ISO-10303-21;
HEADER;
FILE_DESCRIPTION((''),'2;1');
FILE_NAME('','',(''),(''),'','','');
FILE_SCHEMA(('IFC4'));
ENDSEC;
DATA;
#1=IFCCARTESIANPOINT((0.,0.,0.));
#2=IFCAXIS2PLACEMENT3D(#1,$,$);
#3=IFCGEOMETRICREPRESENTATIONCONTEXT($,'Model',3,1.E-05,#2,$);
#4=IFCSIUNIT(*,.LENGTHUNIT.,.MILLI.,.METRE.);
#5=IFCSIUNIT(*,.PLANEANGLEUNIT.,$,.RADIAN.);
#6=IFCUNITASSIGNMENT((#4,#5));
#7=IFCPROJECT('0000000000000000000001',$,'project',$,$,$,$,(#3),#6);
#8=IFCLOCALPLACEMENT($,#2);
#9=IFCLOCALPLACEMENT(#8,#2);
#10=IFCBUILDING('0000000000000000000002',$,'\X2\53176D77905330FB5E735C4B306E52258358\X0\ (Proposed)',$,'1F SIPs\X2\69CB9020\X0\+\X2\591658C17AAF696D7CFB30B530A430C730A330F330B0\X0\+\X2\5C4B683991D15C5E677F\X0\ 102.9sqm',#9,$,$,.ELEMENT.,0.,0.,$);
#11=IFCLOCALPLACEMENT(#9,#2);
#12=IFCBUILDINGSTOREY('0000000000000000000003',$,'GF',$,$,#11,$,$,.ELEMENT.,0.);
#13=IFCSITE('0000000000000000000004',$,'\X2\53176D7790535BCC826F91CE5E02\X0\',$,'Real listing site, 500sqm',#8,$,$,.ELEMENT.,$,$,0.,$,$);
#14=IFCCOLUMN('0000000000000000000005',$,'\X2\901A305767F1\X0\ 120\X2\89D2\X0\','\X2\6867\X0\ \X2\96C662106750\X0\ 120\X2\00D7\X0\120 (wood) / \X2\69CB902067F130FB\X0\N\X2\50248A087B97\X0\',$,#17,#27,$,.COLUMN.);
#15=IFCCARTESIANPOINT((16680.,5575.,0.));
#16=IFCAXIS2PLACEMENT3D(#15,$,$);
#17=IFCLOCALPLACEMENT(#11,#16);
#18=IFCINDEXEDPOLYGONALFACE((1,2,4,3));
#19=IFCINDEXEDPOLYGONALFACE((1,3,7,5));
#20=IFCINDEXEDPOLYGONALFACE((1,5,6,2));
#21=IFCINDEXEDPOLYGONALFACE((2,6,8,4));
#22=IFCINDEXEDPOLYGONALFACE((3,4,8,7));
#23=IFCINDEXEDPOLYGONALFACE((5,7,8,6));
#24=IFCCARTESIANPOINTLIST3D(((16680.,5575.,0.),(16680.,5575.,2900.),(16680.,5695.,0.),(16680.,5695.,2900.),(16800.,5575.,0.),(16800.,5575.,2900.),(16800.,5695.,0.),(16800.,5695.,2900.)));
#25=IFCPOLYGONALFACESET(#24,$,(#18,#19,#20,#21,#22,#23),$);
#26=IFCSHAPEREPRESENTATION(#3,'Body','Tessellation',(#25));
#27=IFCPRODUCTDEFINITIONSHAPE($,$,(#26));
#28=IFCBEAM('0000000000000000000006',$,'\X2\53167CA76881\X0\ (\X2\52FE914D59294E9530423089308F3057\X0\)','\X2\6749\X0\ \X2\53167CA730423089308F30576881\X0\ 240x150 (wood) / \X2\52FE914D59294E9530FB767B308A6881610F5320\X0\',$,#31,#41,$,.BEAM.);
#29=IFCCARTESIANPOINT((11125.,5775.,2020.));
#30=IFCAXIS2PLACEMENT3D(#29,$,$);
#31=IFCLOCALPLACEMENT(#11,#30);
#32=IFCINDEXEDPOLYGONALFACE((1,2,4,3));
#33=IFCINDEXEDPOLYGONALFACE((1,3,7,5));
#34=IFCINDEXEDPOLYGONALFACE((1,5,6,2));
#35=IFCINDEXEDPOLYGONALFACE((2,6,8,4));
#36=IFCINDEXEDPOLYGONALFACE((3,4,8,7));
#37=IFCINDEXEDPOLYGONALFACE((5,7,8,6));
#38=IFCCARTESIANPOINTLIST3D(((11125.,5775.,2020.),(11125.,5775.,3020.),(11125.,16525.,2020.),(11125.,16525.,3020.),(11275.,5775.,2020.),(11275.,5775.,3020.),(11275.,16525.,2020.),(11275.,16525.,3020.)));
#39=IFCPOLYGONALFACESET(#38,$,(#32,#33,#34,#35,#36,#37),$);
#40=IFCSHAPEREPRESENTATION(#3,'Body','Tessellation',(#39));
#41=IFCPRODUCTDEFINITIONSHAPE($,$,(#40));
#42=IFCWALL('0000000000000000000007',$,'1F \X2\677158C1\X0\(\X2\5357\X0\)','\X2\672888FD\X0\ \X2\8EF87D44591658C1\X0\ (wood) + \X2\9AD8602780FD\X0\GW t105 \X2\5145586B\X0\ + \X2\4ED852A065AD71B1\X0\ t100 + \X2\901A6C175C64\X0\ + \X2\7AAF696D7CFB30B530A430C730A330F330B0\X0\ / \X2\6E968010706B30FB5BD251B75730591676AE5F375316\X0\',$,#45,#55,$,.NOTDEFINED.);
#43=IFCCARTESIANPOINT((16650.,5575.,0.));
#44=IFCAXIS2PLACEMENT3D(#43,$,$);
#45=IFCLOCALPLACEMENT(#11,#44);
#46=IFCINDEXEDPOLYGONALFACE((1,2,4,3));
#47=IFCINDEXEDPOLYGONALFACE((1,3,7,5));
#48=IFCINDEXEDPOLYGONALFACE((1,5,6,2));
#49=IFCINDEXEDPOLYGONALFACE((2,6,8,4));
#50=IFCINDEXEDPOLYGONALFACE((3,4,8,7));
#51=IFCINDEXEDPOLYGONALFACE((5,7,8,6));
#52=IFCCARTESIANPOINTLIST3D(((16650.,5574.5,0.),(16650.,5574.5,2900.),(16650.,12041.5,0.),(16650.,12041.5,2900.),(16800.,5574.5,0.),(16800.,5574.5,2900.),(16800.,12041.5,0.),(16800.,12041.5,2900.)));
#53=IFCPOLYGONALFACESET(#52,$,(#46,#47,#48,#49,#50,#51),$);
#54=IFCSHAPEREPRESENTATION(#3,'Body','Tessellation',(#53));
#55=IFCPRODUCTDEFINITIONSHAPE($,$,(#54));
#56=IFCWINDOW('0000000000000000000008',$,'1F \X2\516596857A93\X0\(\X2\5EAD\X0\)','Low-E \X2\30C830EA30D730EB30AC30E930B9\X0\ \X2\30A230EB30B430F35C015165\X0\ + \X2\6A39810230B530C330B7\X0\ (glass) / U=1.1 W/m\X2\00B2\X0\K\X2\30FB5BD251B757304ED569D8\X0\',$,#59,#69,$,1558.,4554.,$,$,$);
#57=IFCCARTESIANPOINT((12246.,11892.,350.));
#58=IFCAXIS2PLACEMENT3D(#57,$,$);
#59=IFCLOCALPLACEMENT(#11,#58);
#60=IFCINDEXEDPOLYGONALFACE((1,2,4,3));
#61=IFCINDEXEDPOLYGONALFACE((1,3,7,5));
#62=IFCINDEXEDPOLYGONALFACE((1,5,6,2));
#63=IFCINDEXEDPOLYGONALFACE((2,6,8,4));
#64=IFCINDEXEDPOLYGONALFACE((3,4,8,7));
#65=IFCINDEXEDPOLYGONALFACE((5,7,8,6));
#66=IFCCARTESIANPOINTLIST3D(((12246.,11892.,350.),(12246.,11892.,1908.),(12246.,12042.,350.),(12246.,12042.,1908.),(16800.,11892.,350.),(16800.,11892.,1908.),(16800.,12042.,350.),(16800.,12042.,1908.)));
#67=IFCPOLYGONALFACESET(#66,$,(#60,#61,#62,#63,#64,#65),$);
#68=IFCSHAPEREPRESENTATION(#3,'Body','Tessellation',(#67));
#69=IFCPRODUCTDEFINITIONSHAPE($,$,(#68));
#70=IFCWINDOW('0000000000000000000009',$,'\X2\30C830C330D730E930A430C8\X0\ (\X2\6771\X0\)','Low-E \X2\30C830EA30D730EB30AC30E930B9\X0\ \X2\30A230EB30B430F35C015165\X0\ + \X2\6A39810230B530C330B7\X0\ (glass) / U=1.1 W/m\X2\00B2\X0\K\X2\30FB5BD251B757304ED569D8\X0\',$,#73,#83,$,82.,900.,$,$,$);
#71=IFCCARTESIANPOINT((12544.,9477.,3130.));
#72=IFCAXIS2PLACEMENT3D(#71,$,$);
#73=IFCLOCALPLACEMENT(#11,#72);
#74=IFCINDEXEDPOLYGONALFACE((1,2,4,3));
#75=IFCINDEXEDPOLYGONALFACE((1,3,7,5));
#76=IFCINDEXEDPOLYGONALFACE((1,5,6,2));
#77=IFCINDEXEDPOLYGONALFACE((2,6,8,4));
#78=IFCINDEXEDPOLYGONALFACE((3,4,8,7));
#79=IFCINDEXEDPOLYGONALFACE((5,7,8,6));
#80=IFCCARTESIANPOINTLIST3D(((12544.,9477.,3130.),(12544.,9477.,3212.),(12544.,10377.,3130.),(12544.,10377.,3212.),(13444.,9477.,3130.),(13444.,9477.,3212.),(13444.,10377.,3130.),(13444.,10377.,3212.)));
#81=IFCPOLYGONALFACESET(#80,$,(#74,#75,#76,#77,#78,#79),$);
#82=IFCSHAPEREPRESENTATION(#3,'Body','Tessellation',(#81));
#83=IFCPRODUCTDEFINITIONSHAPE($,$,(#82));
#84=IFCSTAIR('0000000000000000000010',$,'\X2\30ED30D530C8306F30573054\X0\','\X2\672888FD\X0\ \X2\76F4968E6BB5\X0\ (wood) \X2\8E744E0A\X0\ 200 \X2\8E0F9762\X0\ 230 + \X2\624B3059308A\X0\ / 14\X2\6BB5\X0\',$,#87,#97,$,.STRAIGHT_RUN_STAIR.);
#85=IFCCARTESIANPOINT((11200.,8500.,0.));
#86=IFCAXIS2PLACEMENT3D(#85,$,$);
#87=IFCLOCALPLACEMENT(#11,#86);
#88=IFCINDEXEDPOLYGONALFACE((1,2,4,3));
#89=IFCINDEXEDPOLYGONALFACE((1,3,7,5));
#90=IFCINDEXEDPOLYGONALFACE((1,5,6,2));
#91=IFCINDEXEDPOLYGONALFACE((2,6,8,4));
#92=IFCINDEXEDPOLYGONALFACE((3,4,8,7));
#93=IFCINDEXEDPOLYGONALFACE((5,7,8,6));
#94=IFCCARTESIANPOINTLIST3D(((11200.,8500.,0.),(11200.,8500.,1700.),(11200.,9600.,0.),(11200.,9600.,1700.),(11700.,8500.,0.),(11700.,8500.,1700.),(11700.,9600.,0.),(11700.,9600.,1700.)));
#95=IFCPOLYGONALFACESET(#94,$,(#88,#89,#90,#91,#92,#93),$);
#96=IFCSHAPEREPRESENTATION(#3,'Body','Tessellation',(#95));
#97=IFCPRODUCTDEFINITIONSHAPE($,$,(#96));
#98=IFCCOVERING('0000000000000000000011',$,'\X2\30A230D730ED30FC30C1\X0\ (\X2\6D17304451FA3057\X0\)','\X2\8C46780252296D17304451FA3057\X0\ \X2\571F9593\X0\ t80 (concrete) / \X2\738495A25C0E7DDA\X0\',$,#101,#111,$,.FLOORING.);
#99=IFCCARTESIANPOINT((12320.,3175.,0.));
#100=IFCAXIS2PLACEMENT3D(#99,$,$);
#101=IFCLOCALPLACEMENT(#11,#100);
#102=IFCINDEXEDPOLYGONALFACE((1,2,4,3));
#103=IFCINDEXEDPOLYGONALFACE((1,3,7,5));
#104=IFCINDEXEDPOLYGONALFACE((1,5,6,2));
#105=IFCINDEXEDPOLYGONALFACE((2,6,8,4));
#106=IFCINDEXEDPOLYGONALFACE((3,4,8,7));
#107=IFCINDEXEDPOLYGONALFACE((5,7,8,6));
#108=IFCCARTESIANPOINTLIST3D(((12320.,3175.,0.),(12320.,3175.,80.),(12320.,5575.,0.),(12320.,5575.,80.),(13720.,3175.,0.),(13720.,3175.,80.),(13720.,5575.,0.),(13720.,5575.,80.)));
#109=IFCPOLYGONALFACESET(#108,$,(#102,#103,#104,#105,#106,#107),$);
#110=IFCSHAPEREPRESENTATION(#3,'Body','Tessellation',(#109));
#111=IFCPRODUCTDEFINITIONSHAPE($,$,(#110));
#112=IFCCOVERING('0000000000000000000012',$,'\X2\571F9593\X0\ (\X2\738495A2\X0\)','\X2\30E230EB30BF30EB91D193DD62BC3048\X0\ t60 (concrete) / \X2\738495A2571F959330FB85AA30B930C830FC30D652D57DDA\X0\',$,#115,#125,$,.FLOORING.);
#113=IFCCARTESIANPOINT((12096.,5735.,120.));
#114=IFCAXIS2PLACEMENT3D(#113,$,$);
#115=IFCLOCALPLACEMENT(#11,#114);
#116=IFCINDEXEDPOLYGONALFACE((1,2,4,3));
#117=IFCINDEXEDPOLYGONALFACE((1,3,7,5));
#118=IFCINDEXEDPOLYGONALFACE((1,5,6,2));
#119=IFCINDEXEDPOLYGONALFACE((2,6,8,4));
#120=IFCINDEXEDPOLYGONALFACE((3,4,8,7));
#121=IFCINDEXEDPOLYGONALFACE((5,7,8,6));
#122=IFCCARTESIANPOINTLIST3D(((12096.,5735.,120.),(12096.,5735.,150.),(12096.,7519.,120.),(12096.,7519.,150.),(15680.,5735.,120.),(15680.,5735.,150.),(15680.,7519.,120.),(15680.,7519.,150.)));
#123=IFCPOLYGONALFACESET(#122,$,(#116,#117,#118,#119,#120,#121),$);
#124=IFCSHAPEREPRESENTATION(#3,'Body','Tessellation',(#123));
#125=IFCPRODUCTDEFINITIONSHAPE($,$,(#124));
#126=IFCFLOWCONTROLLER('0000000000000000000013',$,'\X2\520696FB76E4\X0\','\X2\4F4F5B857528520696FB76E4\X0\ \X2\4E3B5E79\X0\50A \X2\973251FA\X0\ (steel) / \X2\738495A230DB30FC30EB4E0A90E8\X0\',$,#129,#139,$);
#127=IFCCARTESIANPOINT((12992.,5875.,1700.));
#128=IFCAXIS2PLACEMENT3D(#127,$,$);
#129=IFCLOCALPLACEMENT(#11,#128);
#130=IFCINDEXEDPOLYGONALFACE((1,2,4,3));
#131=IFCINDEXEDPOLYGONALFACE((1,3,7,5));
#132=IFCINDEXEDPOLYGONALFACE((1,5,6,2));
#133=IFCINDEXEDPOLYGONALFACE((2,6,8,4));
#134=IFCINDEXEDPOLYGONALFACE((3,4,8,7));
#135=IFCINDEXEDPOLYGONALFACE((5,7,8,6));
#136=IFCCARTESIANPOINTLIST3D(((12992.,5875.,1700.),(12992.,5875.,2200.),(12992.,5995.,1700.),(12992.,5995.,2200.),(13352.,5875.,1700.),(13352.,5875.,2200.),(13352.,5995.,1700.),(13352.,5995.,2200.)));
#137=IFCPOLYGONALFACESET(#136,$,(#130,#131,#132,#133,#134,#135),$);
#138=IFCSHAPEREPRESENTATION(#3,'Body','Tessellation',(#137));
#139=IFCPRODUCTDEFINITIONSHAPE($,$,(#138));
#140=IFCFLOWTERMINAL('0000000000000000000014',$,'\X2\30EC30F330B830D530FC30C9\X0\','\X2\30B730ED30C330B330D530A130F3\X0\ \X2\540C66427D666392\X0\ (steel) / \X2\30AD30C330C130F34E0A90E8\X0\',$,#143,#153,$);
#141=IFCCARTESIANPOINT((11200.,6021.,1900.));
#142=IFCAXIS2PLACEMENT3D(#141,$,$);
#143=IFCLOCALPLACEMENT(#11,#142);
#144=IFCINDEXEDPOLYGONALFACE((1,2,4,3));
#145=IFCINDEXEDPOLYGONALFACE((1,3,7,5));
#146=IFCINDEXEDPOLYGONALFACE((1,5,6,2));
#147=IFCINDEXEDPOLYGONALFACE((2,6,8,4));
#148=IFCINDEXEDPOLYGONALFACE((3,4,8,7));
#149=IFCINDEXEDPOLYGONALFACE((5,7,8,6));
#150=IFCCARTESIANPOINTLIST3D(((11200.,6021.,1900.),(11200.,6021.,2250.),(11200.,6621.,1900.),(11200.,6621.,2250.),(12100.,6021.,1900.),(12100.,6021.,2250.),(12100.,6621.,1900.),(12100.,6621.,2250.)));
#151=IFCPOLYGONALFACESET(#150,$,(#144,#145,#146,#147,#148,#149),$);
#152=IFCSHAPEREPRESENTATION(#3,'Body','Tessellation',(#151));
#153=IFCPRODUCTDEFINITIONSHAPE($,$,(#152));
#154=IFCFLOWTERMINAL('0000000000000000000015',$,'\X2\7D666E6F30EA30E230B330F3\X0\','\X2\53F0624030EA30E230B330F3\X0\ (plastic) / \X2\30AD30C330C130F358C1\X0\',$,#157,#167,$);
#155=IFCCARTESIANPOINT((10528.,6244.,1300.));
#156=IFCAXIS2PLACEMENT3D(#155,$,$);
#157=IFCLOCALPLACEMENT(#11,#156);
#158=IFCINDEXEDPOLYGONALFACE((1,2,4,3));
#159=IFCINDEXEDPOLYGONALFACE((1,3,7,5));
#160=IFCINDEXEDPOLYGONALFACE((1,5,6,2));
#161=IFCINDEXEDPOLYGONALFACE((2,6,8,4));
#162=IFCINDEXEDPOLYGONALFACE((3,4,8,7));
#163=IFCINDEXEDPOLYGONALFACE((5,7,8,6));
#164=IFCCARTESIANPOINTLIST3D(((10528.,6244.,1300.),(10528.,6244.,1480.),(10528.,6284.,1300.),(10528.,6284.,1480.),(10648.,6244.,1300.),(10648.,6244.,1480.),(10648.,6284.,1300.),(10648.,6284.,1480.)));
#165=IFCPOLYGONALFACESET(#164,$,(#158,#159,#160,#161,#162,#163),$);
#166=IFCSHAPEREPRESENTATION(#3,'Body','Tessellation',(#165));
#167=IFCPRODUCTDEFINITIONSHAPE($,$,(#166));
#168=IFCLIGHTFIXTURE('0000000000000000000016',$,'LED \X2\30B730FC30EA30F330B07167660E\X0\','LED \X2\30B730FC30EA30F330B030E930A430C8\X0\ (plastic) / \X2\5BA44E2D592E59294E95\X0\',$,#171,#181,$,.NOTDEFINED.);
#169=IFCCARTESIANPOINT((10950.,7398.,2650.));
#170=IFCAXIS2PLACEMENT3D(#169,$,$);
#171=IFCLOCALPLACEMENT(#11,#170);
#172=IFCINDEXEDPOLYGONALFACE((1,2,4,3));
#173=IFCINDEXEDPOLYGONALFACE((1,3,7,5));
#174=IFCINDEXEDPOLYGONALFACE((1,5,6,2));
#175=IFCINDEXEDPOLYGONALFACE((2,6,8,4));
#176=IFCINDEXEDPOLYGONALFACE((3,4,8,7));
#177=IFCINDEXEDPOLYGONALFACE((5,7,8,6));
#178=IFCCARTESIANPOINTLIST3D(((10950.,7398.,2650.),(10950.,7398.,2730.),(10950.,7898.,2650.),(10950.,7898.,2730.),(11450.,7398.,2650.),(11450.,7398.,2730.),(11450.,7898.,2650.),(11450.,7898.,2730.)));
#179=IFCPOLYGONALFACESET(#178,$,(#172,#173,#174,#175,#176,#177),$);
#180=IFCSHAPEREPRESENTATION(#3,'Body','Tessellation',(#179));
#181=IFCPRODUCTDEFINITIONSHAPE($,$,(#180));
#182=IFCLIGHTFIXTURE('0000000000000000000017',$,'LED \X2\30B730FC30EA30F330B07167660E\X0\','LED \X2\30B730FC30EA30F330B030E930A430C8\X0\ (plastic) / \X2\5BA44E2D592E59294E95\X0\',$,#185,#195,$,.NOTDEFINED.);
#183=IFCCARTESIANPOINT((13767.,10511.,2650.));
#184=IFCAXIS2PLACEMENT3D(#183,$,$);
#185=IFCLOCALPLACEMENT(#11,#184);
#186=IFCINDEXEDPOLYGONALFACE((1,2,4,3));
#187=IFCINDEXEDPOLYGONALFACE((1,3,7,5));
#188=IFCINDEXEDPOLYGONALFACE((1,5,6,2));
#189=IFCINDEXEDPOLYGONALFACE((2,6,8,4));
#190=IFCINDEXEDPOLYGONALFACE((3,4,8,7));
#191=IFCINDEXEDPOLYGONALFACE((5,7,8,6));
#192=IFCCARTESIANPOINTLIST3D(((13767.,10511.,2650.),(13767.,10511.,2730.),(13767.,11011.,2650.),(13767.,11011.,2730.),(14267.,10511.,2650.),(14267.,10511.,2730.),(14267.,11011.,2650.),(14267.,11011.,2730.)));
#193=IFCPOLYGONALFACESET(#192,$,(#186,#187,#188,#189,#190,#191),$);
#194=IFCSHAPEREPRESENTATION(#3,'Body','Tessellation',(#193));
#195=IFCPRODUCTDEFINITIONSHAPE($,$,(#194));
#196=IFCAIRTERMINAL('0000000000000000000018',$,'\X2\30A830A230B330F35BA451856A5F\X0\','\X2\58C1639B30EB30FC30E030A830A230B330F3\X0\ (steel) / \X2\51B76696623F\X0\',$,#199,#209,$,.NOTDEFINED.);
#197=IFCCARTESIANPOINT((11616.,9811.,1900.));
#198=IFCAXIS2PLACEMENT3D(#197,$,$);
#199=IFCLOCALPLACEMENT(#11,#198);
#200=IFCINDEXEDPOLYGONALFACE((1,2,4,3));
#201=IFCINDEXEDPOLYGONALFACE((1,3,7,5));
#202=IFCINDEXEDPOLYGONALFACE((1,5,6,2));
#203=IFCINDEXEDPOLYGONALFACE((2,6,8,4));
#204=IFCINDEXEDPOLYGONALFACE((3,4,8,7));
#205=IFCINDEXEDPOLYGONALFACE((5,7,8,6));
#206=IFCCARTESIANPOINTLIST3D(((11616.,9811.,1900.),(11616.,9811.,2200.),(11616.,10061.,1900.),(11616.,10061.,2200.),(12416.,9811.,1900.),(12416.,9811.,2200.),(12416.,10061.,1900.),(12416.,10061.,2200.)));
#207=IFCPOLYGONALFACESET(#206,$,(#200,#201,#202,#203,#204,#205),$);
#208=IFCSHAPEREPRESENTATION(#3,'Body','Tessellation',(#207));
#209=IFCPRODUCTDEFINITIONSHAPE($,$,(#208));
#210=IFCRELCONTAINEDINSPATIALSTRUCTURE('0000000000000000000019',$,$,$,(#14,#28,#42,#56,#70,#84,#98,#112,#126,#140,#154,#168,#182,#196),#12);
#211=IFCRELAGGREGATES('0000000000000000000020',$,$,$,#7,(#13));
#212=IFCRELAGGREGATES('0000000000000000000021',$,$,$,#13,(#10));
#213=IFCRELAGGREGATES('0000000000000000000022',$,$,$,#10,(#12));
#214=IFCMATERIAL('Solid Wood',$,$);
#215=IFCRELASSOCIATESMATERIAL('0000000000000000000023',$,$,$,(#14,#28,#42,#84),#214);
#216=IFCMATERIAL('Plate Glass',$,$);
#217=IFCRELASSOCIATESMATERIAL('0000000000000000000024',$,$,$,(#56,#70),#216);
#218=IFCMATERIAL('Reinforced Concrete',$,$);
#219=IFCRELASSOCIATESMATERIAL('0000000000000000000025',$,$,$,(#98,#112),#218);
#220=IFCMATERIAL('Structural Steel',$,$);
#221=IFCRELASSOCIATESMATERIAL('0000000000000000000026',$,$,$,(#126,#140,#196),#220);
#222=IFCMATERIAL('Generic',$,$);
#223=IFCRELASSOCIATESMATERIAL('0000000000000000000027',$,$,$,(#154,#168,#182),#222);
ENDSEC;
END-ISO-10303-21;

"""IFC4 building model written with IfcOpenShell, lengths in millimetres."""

from ifc_helpers import new_model, si_unit, frame, frame_2d, origin, place, context, project, spatial, rectangle, extrude, material, element, fill, save


model = new_model("IFC4")

# Units and contexts
model_context = context("Model", 3, precision=1e-05, world=origin())
ifc_project = project(units=[si_unit("LENGTHUNIT", "METRE", prefix="MILLI"), si_unit("PLANEANGLEUNIT", "RADIAN")], contexts=[model_context])

# Site, building, storey
site_placement = place(None, origin())
site = spatial("IfcSite", under=ifc_project, at=site_placement, Name="北海道富良野市", ObjectType="Real listing site, 500sqm", CompositionType="ELEMENT", RefElevation=0.0)
building_placement = place(site_placement, origin())
building = spatial("IfcBuilding", under=site, at=building_placement, Name="北海道・平屋の別荘 (Proposed)", ObjectType="1F SIPs構造+外壁窯業系サイディング+屋根金属板 102.9sqm", CompositionType="ELEMENT", ElevationOfRefHeight=0.0, ElevationOfTerrain=0.0)
storey_placement = place(building_placement, origin())
storey = spatial("IfcBuildingStorey", under=building, at=storey_placement, Name="GF", CompositionType="ELEMENT", Elevation=0.0)

# Column
ifc_material_1 = material(Name="Solid Wood")
column_1_placement = place(storey_placement, frame((16680.0, 5575.0, 0.0)))
element("IfcColumn", 1, at=column_1_placement, inside=storey, material=ifc_material_1, Name="通し柱 120角", Description="桧 集成材 120×120 (wood) / 構造柱・N値計算", PredefinedType="COLUMN", context=model_context, shape_type="SweptSolid", body=[
    extrude(rectangle(XDim=120.0, YDim=120.0, at=frame_2d((60.0, 60.0))), frame((16680.0, 5575.0, 0.0)), (0.0, 0.0, 1.0), 2900.0),
])

# Beam
beam_1_placement = place(storey_placement, frame((11125.0, 5775.0, 2020.0)))
element("IfcBeam", 2, at=beam_1_placement, inside=storey, material=ifc_material_1, Name="化粧梁 (勾配天井あらわし)", Description="杉 化粧あらわし梁 240x150 (wood) / 勾配天井・登り梁意匠", PredefinedType="BEAM", context=model_context, shape_type="SweptSolid", body=[
    extrude(rectangle(XDim=150.0, YDim=10750.0, at=frame_2d((75.0, 5375.0))), frame((11125.0, 5775.0, 2020.0)), (0.0, 0.0, 1.0), 1000.0),
])

# Wall, opening, window
wall_1_placement = place(storey_placement, frame((16650.0, 5575.0, 0.0)))
wall_1 = element("IfcWall", 3, at=wall_1_placement, inside=storey, material=ifc_material_1, Name="1F 東壁(南)", Description="木製 軸組外壁 (wood) + 高性能GW t105 充填 + 付加断熱 t100 + 通気層 + 窯業系サイディング / 準耐火・寒冷地外皮強化", PredefinedType="NOTDEFINED", context=model_context, shape_type="SweptSolid", body=[
    extrude(rectangle(XDim=150.0, YDim=6467.0, at=frame_2d((75.0, 3233.0))), frame((16650.0, 5575.0, 0.0)), (0.0, 0.0, 1.0), 2900.0),
])
opening_placement = place(storey_placement, frame((12246.0, 11892.0, 350.0)))
opening = element("IfcOpeningElement", 4, at=opening_placement, cuts=wall_1, PredefinedType="NOTDEFINED", context=model_context, shape_type="SweptSolid", body=[
    extrude(rectangle(XDim=4554.0, YDim=150.0, at=frame_2d((2277.0, 75.0))), frame((12246.0, 11892.0, 350.0)), (0.0, 0.0, 1.0), 1558.0),
])
ifc_material_2 = material(Name="Plate Glass")
window_1_placement = place(storey_placement, frame((12246.0, 11892.0, 350.0)))
window_1 = element("IfcWindow", 5, at=window_1_placement, inside=storey, material=ifc_material_2, Name="1F 入隅窓(庭)", Description="Low-E トリプルガラス アルゴン封入 + 樹脂サッシ (glass) / U=1.1 W/m²K・寒冷地仕様", OverallHeight=1558.0, OverallWidth=4554.0, context=model_context, shape_type="SweptSolid", body=[
    extrude(rectangle(XDim=4554.0, YDim=150.0, at=frame_2d((2277.0, 75.0))), frame((12246.0, 11892.0, 350.0)), (0.0, 0.0, 1.0), 1558.0),
])
fill(opening, window_1)

# Window
window_2_placement = place(storey_placement, frame((12544.0, 9477.0, 3130.0)))
element("IfcWindow", 6, at=window_2_placement, inside=storey, material=ifc_material_2, Name="トップライト (東)", Description="Low-E トリプルガラス アルゴン封入 + 樹脂サッシ (glass) / U=1.1 W/m²K・寒冷地仕様", OverallHeight=82.0, OverallWidth=900.0, context=model_context, shape_type="SweptSolid", body=[
    extrude(rectangle(XDim=900.0, YDim=900.0, at=frame_2d((450.0, 450.0))), frame((12544.0, 9477.0, 3130.0)), (0.0, 0.0, 1.0), 82.0),
])

# Stair
stair_placement = place(storey_placement, frame((11200.0, 8500.0, 0.0)))
element("IfcStair", 7, at=stair_placement, inside=storey, material=ifc_material_1, Name="ロフトはしご", Description="木製 直階段 (wood) 蹴上 200 踏面 230 + 手すり / 14段", PredefinedType="STRAIGHT_RUN_STAIR", context=model_context, shape_type="SweptSolid", body=[
    extrude(rectangle(XDim=500.0, YDim=1100.0, at=frame_2d((250.0, 550.0))), frame((11200.0, 8500.0, 0.0)), (0.0, 0.0, 1.0), 1700.0),
])

# Coverings
ifc_material_3 = material(Name="Reinforced Concrete")
covering_1_placement = place(storey_placement, frame((12320.0, 3175.0, 0.0)))
element("IfcCovering", 8, at=covering_1_placement, inside=storey, material=ifc_material_3, Name="アプローチ (洗い出し)", Description="豆砂利洗い出し 土間 t80 (concrete) / 玄関導線", PredefinedType="FLOORING", context=model_context, shape_type="SweptSolid", body=[
    extrude(rectangle(XDim=1400.0, YDim=2400.0, at=frame_2d((700.0, 1200.0))), frame((12320.0, 3175.0, 0.0)), (0.0, 0.0, 1.0), 80.0),
])
covering_2_placement = place(storey_placement, frame((12096.0, 5735.0, 120.0)))
element("IfcCovering", 9, at=covering_2_placement, inside=storey, material=ifc_material_3, Name="土間 (玄関)", Description="モルタル金鏝押え t60 (concrete) / 玄関土間・薪ストーブ動線", PredefinedType="FLOORING", context=model_context, shape_type="SweptSolid", body=[
    extrude(rectangle(XDim=3584.0, YDim=1784.0, at=frame_2d((1792.0, 892.0))), frame((12096.0, 5735.0, 120.0)), (0.0, 0.0, 1.0), 30.0),
])

# Flow controller
ifc_material_4 = material(Name="Structural Steel")
flow_controller_placement = place(storey_placement, frame((12992.0, 5875.0, 1700.0)))
element("IfcFlowController", 10, at=flow_controller_placement, inside=storey, material=ifc_material_4, Name="分電盤", Description="住宅用分電盤 主幹50A 露出 (steel) / 玄関ホール上部", context=model_context, shape_type="SweptSolid", body=[
    extrude(rectangle(XDim=360.0, YDim=120.0, at=frame_2d((180.0, 60.0))), frame((12992.0, 5875.0, 1700.0)), (0.0, 0.0, 1.0), 500.0),
])

# Flow terminals
flow_terminal_1_placement = place(storey_placement, frame((11200.0, 6021.0, 1900.0)))
element("IfcFlowTerminal", 11, at=flow_terminal_1_placement, inside=storey, material=ifc_material_4, Name="レンジフード", Description="シロッコファン 同時給排 (steel) / キッチン上部", context=model_context, shape_type="SweptSolid", body=[
    extrude(rectangle(XDim=900.0, YDim=600.0, at=frame_2d((450.0, 300.0))), frame((11200.0, 6021.0, 1900.0)), (0.0, 0.0, 1.0), 350.0),
])
ifc_material_5 = material(Name="Generic")
flow_terminal_2_placement = place(storey_placement, frame((10528.0, 6244.0, 1300.0)))
element("IfcFlowTerminal", 12, at=flow_terminal_2_placement, inside=storey, material=ifc_material_5, Name="給湯リモコン", Description="台所リモコン (plastic) / キッチン壁", context=model_context, shape_type="SweptSolid", body=[
    extrude(rectangle(XDim=120.0, YDim=40.0, at=frame_2d((60.0, 20.0))), frame((10528.0, 6244.0, 1300.0)), (0.0, 0.0, 1.0), 180.0),
])

# Light fixtures
light_fixture_1_placement = place(storey_placement, frame((10950.0, 7398.0, 2650.0)))
element("IfcLightFixture", 13, at=light_fixture_1_placement, inside=storey, material=ifc_material_5, Name="LED シーリング照明", Description="LED シーリングライト (plastic) / 室中央天井", PredefinedType="NOTDEFINED", context=model_context, shape_type="SweptSolid", body=[
    extrude(rectangle(XDim=500.0, YDim=500.0, at=frame_2d((250.0, 250.0))), frame((10950.0, 7398.0, 2650.0)), (0.0, 0.0, 1.0), 80.0),
])
light_fixture_2_placement = place(storey_placement, frame((13767.0, 10511.0, 2650.0)))
element("IfcLightFixture", 14, at=light_fixture_2_placement, inside=storey, material=ifc_material_5, Name="LED シーリング照明", Description="LED シーリングライト (plastic) / 室中央天井", PredefinedType="NOTDEFINED", context=model_context, shape_type="SweptSolid", body=[
    extrude(rectangle(XDim=500.0, YDim=500.0, at=frame_2d((250.0, 250.0))), frame((13767.0, 10511.0, 2650.0)), (0.0, 0.0, 1.0), 80.0),
])

# Air terminal
air_terminal_placement = place(storey_placement, frame((11616.0, 9811.0, 1900.0)))
element("IfcAirTerminal", 15, at=air_terminal_placement, inside=storey, material=ifc_material_4, Name="エアコン室内機", Description="壁掛ルームエアコン (steel) / 冷暖房", PredefinedType="NOTDEFINED", context=model_context, shape_type="SweptSolid", body=[
    extrude(rectangle(XDim=800.0, YDim=250.0, at=frame_2d((400.0, 125.0))), frame((11616.0, 9811.0, 1900.0)), (0.0, 0.0, 1.0), 300.0),
])

save(model, "model.ifc")
